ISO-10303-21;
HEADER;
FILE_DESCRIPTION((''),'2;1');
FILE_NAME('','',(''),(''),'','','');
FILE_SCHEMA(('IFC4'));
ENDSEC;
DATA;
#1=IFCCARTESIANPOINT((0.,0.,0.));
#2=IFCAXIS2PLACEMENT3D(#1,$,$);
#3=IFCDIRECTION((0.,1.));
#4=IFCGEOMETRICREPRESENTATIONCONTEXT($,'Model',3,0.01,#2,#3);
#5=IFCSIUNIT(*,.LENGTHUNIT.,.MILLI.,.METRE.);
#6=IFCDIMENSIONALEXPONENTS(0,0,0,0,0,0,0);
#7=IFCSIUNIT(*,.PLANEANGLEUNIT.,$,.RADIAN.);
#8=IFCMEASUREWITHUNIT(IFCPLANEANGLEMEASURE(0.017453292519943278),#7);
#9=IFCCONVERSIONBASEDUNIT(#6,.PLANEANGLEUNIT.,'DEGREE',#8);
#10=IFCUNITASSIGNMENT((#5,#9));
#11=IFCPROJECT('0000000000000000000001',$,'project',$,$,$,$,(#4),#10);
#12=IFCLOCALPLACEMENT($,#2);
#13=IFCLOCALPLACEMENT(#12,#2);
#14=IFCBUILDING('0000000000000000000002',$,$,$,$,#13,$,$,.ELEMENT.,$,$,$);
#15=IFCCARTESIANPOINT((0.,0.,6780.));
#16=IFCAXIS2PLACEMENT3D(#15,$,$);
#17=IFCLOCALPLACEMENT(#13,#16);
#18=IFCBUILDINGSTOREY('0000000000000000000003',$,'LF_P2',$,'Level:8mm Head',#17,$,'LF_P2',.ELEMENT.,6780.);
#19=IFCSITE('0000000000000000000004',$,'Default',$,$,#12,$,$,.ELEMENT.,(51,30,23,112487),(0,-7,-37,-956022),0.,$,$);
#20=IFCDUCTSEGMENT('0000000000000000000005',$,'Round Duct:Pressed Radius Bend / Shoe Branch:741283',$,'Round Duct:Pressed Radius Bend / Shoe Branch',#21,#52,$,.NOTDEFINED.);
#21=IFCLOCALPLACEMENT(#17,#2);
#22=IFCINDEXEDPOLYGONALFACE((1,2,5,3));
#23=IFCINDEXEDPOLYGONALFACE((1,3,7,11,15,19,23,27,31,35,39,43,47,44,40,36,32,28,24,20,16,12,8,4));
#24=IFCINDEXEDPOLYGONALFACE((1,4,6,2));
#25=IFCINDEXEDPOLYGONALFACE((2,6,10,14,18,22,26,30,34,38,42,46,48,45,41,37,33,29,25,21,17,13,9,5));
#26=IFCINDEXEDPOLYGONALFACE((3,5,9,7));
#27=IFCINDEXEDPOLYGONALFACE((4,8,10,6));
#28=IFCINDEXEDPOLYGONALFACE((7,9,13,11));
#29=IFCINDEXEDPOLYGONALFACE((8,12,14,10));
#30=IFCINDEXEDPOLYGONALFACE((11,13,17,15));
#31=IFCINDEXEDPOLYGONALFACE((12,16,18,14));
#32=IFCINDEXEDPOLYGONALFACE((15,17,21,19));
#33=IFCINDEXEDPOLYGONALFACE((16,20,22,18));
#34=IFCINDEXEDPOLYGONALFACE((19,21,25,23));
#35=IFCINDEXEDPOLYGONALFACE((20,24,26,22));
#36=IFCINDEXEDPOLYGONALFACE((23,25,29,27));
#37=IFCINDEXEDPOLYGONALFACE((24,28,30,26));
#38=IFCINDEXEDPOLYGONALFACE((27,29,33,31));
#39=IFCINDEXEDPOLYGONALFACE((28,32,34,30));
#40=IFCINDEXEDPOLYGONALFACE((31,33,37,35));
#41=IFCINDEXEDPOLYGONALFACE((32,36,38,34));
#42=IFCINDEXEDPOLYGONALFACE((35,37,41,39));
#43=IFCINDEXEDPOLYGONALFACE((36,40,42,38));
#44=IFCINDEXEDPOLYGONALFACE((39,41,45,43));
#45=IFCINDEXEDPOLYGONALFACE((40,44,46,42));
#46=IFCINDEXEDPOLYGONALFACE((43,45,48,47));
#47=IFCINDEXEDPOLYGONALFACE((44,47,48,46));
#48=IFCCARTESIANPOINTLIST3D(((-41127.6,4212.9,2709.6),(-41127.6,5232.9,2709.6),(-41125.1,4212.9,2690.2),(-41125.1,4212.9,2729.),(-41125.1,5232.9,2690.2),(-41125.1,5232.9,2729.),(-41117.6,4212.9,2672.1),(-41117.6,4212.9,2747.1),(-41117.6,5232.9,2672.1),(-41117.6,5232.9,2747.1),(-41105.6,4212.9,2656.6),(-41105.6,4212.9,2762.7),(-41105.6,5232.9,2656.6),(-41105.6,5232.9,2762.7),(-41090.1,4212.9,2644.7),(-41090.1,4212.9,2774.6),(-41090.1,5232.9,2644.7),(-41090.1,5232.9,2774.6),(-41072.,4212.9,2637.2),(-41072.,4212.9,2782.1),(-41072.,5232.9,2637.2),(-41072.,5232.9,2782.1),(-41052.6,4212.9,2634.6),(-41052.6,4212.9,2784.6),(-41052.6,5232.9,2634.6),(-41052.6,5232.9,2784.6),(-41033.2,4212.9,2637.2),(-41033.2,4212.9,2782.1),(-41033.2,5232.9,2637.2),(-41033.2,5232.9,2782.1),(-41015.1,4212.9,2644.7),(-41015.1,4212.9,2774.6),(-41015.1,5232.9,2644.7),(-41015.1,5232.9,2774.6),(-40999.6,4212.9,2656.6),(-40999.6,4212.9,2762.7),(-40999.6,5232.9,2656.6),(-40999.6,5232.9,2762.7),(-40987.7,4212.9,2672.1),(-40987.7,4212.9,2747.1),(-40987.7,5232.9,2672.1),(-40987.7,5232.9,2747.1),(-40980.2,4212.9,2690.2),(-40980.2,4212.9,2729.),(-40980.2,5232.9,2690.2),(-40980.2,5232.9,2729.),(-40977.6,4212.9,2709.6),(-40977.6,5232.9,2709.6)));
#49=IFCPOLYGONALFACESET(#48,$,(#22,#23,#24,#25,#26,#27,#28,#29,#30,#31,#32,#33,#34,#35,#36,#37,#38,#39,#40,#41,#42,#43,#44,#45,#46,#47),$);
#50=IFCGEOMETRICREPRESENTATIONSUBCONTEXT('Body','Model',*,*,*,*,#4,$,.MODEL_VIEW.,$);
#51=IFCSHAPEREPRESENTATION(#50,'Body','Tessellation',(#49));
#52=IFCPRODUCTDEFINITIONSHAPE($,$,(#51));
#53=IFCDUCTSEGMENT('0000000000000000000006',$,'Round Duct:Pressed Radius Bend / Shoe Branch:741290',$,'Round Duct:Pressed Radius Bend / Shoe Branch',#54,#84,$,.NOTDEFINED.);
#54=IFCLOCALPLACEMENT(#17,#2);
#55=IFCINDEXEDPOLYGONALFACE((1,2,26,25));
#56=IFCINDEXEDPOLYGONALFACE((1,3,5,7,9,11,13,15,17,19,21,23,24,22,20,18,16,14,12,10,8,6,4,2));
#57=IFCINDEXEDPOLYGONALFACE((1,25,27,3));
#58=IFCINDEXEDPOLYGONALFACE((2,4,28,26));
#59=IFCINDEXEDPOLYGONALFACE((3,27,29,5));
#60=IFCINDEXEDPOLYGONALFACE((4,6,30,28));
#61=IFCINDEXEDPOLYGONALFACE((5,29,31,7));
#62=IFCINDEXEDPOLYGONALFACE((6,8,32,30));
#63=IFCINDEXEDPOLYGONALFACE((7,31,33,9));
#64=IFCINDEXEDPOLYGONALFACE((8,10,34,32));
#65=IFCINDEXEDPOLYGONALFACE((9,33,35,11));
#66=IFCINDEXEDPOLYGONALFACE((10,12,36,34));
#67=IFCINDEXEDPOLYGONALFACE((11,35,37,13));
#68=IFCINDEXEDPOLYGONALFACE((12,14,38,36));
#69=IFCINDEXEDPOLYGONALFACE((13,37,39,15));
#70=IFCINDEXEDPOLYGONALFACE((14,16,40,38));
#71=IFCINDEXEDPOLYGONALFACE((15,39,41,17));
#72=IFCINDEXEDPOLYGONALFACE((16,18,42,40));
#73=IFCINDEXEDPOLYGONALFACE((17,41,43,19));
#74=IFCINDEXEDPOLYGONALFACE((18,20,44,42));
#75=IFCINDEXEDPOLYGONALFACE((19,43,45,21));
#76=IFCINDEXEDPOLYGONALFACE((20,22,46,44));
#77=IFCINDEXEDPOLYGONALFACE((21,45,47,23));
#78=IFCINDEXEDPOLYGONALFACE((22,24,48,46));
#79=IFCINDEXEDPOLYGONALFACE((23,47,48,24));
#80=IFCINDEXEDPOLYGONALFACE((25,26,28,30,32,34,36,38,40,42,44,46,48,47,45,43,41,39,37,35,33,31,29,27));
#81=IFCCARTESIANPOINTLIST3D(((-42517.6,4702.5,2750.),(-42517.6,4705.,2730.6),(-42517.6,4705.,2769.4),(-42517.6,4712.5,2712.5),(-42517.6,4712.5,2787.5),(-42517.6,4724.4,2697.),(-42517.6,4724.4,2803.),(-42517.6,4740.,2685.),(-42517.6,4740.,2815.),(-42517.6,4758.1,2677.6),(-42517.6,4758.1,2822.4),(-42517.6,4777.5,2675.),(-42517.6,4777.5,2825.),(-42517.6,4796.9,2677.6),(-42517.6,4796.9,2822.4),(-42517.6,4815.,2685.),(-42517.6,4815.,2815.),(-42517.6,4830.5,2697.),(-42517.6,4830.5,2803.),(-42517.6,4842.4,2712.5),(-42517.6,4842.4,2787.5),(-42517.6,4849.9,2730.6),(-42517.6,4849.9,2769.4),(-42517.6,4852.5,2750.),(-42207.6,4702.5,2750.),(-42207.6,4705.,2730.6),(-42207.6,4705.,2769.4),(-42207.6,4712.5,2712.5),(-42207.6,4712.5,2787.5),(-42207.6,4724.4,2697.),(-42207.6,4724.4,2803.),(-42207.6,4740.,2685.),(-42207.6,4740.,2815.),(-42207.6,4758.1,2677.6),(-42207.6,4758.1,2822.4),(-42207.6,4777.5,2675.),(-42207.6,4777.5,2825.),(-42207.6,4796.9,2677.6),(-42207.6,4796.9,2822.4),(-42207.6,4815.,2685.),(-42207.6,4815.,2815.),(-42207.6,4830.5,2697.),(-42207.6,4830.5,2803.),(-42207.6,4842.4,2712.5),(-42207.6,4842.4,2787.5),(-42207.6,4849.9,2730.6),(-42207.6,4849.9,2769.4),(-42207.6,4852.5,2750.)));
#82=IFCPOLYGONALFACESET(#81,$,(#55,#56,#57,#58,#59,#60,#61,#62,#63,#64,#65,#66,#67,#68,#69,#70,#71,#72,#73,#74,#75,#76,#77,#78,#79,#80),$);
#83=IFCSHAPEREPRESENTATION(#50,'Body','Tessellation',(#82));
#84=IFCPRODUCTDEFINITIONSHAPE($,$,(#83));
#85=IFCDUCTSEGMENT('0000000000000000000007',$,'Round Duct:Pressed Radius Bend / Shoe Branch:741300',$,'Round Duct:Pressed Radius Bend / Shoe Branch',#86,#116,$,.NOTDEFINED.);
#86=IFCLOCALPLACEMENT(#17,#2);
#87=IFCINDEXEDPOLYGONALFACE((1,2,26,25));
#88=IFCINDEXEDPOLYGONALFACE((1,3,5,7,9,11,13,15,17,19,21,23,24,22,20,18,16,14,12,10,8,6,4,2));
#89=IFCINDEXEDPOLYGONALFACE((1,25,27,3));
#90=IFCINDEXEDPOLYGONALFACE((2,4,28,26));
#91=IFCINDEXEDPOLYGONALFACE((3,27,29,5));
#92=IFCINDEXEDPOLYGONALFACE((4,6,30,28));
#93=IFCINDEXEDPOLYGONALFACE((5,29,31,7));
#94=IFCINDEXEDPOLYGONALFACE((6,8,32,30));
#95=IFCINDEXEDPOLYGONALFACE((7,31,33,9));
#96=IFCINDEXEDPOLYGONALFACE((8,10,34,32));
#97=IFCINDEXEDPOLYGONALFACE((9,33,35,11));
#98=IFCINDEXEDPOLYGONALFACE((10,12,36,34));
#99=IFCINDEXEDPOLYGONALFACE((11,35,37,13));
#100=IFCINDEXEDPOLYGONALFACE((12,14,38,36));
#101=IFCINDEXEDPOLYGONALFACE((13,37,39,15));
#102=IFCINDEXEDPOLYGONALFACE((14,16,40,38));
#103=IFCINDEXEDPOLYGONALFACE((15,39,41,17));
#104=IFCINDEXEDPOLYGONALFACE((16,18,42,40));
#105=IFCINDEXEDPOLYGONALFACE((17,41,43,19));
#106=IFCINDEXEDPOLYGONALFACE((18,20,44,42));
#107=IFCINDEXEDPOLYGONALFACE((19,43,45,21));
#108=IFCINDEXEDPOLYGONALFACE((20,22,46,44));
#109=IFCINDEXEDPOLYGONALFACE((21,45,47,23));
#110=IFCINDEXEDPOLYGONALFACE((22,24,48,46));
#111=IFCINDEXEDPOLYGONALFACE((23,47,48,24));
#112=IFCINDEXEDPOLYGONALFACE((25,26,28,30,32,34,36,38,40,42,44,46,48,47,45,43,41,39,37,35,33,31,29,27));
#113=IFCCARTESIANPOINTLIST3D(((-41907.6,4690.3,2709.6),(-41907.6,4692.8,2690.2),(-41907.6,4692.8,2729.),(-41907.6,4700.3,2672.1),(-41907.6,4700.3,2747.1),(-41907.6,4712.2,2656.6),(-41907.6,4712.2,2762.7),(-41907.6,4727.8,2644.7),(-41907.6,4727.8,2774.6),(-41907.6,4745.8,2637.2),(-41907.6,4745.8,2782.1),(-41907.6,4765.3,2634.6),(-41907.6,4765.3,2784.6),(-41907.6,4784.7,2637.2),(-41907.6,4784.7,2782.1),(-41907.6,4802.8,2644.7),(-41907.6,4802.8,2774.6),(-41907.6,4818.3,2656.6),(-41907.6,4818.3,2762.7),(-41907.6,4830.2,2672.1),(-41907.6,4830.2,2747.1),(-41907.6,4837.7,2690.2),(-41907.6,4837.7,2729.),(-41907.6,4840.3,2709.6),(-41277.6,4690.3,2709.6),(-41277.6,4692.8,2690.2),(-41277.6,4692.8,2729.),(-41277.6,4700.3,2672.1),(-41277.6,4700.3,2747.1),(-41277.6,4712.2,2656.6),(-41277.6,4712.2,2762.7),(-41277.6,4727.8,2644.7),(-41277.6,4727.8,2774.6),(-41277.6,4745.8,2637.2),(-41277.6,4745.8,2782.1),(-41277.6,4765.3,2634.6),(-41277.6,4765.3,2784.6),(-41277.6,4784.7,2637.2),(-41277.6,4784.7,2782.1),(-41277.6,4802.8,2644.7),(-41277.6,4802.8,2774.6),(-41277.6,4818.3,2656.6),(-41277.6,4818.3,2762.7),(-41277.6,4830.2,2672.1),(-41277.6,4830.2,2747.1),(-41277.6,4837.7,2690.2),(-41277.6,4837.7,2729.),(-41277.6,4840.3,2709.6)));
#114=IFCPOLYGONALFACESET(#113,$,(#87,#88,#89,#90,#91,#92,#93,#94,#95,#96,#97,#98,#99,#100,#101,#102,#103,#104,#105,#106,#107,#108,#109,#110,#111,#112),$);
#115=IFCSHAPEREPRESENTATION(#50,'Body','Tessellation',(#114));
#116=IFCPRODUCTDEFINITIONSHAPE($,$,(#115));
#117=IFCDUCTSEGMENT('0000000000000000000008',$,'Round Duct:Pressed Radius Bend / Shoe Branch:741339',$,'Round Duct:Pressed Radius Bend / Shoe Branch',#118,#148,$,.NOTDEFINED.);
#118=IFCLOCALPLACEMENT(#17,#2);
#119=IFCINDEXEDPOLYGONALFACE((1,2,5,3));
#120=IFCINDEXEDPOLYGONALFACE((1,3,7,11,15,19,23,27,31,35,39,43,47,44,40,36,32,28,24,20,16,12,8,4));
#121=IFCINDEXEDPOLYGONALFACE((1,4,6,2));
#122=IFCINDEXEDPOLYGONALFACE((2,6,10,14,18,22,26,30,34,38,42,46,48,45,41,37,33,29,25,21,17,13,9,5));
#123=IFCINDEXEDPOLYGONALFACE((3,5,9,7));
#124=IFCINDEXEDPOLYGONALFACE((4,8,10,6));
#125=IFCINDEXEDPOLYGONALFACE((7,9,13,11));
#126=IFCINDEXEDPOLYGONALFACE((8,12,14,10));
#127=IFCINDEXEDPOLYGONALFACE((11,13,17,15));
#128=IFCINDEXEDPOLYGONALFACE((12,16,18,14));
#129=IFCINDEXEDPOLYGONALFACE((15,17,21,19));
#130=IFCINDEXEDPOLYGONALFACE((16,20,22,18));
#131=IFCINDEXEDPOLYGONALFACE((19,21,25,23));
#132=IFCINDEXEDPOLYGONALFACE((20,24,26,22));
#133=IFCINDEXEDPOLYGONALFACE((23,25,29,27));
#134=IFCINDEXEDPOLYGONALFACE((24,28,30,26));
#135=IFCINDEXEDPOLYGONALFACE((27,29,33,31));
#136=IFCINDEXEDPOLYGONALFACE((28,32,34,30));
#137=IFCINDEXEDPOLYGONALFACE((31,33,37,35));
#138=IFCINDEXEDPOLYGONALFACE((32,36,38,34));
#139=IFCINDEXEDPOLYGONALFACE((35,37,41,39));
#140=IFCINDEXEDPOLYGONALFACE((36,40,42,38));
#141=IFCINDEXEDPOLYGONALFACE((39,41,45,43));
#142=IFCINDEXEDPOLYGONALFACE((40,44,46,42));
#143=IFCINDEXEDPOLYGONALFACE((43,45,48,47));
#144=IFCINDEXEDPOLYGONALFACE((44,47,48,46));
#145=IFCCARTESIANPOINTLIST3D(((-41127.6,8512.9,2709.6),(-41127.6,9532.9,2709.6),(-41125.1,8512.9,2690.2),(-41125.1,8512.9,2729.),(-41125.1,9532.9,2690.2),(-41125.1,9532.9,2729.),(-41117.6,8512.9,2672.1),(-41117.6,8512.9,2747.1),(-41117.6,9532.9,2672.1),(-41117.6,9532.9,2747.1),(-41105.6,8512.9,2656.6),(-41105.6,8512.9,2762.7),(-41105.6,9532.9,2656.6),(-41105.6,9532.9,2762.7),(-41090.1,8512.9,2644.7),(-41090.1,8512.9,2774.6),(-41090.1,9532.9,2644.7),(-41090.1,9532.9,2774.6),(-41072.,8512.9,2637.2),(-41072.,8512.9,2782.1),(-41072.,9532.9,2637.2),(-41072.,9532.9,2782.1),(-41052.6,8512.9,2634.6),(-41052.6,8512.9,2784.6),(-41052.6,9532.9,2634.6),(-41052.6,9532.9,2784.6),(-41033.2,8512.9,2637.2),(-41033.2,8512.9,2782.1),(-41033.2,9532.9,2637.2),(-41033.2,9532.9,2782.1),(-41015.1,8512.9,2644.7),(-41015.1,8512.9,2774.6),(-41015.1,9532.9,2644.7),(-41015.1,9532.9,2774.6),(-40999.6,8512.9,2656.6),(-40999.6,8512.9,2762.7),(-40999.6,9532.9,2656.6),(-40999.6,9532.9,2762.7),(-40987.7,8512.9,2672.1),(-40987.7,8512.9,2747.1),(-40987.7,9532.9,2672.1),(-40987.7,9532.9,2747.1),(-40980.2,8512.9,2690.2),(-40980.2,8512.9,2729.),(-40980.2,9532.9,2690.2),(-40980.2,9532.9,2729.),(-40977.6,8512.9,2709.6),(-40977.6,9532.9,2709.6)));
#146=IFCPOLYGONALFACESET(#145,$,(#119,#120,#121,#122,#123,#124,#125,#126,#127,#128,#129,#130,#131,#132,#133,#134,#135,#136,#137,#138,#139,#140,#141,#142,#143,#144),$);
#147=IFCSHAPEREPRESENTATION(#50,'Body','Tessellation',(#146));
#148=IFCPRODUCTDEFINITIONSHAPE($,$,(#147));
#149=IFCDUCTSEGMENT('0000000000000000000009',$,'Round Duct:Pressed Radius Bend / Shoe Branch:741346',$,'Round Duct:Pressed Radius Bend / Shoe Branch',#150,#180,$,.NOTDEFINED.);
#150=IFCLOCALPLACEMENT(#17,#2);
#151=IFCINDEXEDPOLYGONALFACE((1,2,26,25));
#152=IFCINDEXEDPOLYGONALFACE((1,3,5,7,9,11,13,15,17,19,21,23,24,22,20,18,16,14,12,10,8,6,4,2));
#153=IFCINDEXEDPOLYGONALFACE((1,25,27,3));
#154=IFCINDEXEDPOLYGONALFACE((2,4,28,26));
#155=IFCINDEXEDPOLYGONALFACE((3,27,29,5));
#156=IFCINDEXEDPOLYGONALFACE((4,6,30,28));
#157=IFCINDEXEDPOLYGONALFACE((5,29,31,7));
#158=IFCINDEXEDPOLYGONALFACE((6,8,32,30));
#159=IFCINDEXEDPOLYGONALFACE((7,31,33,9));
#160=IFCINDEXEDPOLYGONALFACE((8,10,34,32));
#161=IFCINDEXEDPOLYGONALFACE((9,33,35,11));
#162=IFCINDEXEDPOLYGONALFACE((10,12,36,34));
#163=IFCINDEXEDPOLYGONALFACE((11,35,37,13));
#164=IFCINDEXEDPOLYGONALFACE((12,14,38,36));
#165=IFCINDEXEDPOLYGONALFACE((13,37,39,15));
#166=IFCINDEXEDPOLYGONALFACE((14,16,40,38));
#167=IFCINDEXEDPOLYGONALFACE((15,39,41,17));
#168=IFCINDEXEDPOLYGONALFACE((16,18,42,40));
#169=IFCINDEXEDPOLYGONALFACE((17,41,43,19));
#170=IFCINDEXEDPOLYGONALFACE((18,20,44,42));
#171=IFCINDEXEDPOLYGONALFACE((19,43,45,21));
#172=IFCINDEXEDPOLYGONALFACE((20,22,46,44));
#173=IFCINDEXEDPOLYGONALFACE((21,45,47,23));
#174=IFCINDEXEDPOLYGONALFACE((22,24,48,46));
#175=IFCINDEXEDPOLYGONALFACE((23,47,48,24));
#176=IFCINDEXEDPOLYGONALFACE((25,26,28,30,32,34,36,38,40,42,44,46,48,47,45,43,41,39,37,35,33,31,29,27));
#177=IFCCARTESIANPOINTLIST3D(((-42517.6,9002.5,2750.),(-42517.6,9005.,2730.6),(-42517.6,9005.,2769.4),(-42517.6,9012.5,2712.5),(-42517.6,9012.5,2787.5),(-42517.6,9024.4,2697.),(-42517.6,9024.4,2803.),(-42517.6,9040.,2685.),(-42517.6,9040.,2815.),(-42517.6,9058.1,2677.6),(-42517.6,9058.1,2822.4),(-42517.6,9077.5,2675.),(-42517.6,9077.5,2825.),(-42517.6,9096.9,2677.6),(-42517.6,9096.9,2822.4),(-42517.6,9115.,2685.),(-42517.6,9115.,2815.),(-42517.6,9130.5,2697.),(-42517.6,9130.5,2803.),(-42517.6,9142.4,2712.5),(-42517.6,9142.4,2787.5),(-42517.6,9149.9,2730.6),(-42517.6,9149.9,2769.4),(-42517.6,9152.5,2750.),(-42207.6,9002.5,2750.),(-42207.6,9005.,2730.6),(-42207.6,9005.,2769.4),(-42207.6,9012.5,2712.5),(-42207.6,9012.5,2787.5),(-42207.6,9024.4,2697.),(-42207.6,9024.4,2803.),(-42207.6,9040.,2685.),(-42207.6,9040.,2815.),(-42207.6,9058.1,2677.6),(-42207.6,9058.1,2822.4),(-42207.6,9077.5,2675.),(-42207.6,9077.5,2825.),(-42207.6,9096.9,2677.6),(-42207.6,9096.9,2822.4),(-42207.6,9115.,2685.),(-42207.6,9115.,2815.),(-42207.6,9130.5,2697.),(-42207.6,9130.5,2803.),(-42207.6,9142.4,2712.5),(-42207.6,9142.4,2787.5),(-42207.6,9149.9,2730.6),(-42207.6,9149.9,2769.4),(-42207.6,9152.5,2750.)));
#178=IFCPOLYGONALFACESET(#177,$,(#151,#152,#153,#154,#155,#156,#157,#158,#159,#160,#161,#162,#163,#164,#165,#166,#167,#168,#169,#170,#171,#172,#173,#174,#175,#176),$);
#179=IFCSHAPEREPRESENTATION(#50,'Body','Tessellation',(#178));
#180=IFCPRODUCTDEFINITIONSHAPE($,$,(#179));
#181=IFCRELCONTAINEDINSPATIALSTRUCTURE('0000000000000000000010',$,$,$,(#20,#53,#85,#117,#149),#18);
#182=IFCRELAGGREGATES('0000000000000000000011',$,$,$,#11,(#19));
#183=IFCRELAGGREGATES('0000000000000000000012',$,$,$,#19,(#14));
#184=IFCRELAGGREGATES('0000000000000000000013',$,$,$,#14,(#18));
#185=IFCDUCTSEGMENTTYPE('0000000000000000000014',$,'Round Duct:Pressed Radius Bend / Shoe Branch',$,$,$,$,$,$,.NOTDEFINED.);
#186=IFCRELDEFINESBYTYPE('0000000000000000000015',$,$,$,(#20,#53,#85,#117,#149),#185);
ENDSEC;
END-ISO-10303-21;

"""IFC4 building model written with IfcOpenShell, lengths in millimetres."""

from ifc_helpers import new_model, entity, si_unit, converted_unit, direction, frame, origin, place, context, subcontext, project, spatial, arc, indexed_curve, outline, extrude, type_object, element, save


model = new_model("IFC4")

# Units and contexts
model_context = context("Model", 3, precision=0.01, world=origin(), true_north=direction((0.0, 1.0)))
body_context = subcontext(model_context, "Body", "Model", "MODEL_VIEW")
ifc_project = project(units=[si_unit("LENGTHUNIT", "METRE", prefix="MILLI"), converted_unit("PLANEANGLEUNIT", "DEGREE", entity("IfcPlaneAngleMeasure", 0.017453292519943278), si_unit("PLANEANGLEUNIT", "RADIAN"), dimensions=[0, 0, 0, 0, 0, 0, 0])], contexts=[model_context])

# Site, building, storey
site_placement = place(None, origin())
site = spatial("IfcSite", under=ifc_project, at=site_placement, Name="Default", CompositionType="ELEMENT", RefLatitude=(51, 30, 23, 112487), RefLongitude=(0, -7, -37, -956022), RefElevation=0.0)
building_placement = place(site_placement, origin())
building = spatial("IfcBuilding", under=site, at=building_placement, CompositionType="ELEMENT")
storey_placement = place(building_placement, frame((0.0, 0.0, 6780.0)))
storey = spatial("IfcBuildingStorey", under=building, at=storey_placement, Name="LF_P2", ObjectType="Level:8mm Head", LongName="LF_P2", CompositionType="ELEMENT", Elevation=6780.0)

# Duct segments
duct_segment_type_1 = type_object("IfcDuctSegmentType", Name="Round Duct:Pressed Radius Bend / Shoe Branch", PredefinedType="NOTDEFINED")
duct_segment_1_placement = place(storey_placement, origin())
element("IfcDuctSegment", 1, at=duct_segment_1_placement, inside=storey, type_object=duct_segment_type_1, Name="Round Duct:Pressed Radius Bend / Shoe Branch:741283", ObjectType="Round Duct:Pressed Radius Bend / Shoe Branch", PredefinedType="NOTDEFINED", context=body_context, shape_type="SweptSolid", body=[
    extrude(outline(indexed_curve([(75.0, 0.0), (53.0, 53.0), (0.0, 75.0), (-53.0, 53.0), (-75.0, 0.0), (-53.0, -53.0), (0.0, -75.0), (53.0, -53.0)], segments=[arc(1, 2, 3), arc(3, 4, 5), arc(5, 6, 7), arc(7, 8, 1)], self_intersect=False)), frame((-41052.6, 4212.9, 2709.6), z_axis=(0.0, 1.0, 0.0), x_axis=(-1.0, 0.0, 0.0)), (0.0, 0.0, 1.0), 1020.0),
])
duct_segment_2_placement = place(storey_placement, origin())
element("IfcDuctSegment", 2, at=duct_segment_2_placement, inside=storey, type_object=duct_segment_type_1, Name="Round Duct:Pressed Radius Bend / Shoe Branch:741290", ObjectType="Round Duct:Pressed Radius Bend / Shoe Branch", PredefinedType="NOTDEFINED", context=body_context, shape_type="SweptSolid", body=[
    extrude(outline(indexed_curve([(75.0, 0.0), (53.0, 53.0), (0.0, 75.0), (-53.0, 53.0), (-75.0, 0.0), (-53.0, -53.0), (0.0, -75.0), (53.0, -53.0)], segments=[arc(1, 2, 3), arc(3, 4, 5), arc(5, 6, 7), arc(7, 8, 1)], self_intersect=False)), frame((-42517.6, 4777.5, 2750.0), z_axis=(1.0, 0.0, 0.0), x_axis=(0.0, -1.0, 0.0)), (0.0, 0.0, 1.0), 310.0),
])
duct_segment_3_placement = place(storey_placement, origin())
element("IfcDuctSegment", 3, at=duct_segment_3_placement, inside=storey, type_object=duct_segment_type_1, Name="Round Duct:Pressed Radius Bend / Shoe Branch:741300", ObjectType="Round Duct:Pressed Radius Bend / Shoe Branch", PredefinedType="NOTDEFINED", context=body_context, shape_type="SweptSolid", body=[
    extrude(outline(indexed_curve([(75.0, 0.0), (53.0, 53.0), (0.0, 75.0), (-53.0, 53.0), (-75.0, 0.0), (-53.0, -53.0), (0.0, -75.0), (53.0, -53.0)], segments=[arc(1, 2, 3), arc(3, 4, 5), arc(5, 6, 7), arc(7, 8, 1)], self_intersect=False)), frame((-41907.6, 4765.3, 2709.6), z_axis=(1.0, 0.0, 0.0), x_axis=(0.0, 1.0, 0.0)), (0.0, 0.0, 1.0), 630.0),
])
duct_segment_4_placement = place(storey_placement, origin())
element("IfcDuctSegment", 4, at=duct_segment_4_placement, inside=storey, type_object=duct_segment_type_1, Name="Round Duct:Pressed Radius Bend / Shoe Branch:741339", ObjectType="Round Duct:Pressed Radius Bend / Shoe Branch", PredefinedType="NOTDEFINED", context=body_context, shape_type="SweptSolid", body=[
    extrude(outline(indexed_curve([(75.0, 0.0), (53.0, 53.0), (0.0, 75.0), (-53.0, 53.0), (-75.0, 0.0), (-53.0, -53.0), (0.0, -75.0), (53.0, -53.0)], segments=[arc(1, 2, 3), arc(3, 4, 5), arc(5, 6, 7), arc(7, 8, 1)], self_intersect=False)), frame((-41052.6, 8512.9, 2709.6), z_axis=(0.0, 1.0, 0.0), x_axis=(-1.0, 0.0, 0.0)), (0.0, 0.0, 1.0), 1020.0),
])
duct_segment_5_placement = place(storey_placement, origin())
element("IfcDuctSegment", 5, at=duct_segment_5_placement, inside=storey, type_object=duct_segment_type_1, Name="Round Duct:Pressed Radius Bend / Shoe Branch:741346", ObjectType="Round Duct:Pressed Radius Bend / Shoe Branch", PredefinedType="NOTDEFINED", context=body_context, shape_type="SweptSolid", body=[
    extrude(outline(indexed_curve([(75.0, 0.0), (53.0, 53.0), (0.0, 75.0), (-53.0, 53.0), (-75.0, 0.0), (-53.0, -53.0), (0.0, -75.0), (53.0, -53.0)], segments=[arc(1, 2, 3), arc(3, 4, 5), arc(5, 6, 7), arc(7, 8, 1)], self_intersect=False)), frame((-42517.6, 9077.5, 2750.0), z_axis=(1.0, 0.0, 0.0), x_axis=(0.0, -1.0, 0.0)), (0.0, 0.0, 1.0), 310.0),
])

save(model, "model.ifc")
